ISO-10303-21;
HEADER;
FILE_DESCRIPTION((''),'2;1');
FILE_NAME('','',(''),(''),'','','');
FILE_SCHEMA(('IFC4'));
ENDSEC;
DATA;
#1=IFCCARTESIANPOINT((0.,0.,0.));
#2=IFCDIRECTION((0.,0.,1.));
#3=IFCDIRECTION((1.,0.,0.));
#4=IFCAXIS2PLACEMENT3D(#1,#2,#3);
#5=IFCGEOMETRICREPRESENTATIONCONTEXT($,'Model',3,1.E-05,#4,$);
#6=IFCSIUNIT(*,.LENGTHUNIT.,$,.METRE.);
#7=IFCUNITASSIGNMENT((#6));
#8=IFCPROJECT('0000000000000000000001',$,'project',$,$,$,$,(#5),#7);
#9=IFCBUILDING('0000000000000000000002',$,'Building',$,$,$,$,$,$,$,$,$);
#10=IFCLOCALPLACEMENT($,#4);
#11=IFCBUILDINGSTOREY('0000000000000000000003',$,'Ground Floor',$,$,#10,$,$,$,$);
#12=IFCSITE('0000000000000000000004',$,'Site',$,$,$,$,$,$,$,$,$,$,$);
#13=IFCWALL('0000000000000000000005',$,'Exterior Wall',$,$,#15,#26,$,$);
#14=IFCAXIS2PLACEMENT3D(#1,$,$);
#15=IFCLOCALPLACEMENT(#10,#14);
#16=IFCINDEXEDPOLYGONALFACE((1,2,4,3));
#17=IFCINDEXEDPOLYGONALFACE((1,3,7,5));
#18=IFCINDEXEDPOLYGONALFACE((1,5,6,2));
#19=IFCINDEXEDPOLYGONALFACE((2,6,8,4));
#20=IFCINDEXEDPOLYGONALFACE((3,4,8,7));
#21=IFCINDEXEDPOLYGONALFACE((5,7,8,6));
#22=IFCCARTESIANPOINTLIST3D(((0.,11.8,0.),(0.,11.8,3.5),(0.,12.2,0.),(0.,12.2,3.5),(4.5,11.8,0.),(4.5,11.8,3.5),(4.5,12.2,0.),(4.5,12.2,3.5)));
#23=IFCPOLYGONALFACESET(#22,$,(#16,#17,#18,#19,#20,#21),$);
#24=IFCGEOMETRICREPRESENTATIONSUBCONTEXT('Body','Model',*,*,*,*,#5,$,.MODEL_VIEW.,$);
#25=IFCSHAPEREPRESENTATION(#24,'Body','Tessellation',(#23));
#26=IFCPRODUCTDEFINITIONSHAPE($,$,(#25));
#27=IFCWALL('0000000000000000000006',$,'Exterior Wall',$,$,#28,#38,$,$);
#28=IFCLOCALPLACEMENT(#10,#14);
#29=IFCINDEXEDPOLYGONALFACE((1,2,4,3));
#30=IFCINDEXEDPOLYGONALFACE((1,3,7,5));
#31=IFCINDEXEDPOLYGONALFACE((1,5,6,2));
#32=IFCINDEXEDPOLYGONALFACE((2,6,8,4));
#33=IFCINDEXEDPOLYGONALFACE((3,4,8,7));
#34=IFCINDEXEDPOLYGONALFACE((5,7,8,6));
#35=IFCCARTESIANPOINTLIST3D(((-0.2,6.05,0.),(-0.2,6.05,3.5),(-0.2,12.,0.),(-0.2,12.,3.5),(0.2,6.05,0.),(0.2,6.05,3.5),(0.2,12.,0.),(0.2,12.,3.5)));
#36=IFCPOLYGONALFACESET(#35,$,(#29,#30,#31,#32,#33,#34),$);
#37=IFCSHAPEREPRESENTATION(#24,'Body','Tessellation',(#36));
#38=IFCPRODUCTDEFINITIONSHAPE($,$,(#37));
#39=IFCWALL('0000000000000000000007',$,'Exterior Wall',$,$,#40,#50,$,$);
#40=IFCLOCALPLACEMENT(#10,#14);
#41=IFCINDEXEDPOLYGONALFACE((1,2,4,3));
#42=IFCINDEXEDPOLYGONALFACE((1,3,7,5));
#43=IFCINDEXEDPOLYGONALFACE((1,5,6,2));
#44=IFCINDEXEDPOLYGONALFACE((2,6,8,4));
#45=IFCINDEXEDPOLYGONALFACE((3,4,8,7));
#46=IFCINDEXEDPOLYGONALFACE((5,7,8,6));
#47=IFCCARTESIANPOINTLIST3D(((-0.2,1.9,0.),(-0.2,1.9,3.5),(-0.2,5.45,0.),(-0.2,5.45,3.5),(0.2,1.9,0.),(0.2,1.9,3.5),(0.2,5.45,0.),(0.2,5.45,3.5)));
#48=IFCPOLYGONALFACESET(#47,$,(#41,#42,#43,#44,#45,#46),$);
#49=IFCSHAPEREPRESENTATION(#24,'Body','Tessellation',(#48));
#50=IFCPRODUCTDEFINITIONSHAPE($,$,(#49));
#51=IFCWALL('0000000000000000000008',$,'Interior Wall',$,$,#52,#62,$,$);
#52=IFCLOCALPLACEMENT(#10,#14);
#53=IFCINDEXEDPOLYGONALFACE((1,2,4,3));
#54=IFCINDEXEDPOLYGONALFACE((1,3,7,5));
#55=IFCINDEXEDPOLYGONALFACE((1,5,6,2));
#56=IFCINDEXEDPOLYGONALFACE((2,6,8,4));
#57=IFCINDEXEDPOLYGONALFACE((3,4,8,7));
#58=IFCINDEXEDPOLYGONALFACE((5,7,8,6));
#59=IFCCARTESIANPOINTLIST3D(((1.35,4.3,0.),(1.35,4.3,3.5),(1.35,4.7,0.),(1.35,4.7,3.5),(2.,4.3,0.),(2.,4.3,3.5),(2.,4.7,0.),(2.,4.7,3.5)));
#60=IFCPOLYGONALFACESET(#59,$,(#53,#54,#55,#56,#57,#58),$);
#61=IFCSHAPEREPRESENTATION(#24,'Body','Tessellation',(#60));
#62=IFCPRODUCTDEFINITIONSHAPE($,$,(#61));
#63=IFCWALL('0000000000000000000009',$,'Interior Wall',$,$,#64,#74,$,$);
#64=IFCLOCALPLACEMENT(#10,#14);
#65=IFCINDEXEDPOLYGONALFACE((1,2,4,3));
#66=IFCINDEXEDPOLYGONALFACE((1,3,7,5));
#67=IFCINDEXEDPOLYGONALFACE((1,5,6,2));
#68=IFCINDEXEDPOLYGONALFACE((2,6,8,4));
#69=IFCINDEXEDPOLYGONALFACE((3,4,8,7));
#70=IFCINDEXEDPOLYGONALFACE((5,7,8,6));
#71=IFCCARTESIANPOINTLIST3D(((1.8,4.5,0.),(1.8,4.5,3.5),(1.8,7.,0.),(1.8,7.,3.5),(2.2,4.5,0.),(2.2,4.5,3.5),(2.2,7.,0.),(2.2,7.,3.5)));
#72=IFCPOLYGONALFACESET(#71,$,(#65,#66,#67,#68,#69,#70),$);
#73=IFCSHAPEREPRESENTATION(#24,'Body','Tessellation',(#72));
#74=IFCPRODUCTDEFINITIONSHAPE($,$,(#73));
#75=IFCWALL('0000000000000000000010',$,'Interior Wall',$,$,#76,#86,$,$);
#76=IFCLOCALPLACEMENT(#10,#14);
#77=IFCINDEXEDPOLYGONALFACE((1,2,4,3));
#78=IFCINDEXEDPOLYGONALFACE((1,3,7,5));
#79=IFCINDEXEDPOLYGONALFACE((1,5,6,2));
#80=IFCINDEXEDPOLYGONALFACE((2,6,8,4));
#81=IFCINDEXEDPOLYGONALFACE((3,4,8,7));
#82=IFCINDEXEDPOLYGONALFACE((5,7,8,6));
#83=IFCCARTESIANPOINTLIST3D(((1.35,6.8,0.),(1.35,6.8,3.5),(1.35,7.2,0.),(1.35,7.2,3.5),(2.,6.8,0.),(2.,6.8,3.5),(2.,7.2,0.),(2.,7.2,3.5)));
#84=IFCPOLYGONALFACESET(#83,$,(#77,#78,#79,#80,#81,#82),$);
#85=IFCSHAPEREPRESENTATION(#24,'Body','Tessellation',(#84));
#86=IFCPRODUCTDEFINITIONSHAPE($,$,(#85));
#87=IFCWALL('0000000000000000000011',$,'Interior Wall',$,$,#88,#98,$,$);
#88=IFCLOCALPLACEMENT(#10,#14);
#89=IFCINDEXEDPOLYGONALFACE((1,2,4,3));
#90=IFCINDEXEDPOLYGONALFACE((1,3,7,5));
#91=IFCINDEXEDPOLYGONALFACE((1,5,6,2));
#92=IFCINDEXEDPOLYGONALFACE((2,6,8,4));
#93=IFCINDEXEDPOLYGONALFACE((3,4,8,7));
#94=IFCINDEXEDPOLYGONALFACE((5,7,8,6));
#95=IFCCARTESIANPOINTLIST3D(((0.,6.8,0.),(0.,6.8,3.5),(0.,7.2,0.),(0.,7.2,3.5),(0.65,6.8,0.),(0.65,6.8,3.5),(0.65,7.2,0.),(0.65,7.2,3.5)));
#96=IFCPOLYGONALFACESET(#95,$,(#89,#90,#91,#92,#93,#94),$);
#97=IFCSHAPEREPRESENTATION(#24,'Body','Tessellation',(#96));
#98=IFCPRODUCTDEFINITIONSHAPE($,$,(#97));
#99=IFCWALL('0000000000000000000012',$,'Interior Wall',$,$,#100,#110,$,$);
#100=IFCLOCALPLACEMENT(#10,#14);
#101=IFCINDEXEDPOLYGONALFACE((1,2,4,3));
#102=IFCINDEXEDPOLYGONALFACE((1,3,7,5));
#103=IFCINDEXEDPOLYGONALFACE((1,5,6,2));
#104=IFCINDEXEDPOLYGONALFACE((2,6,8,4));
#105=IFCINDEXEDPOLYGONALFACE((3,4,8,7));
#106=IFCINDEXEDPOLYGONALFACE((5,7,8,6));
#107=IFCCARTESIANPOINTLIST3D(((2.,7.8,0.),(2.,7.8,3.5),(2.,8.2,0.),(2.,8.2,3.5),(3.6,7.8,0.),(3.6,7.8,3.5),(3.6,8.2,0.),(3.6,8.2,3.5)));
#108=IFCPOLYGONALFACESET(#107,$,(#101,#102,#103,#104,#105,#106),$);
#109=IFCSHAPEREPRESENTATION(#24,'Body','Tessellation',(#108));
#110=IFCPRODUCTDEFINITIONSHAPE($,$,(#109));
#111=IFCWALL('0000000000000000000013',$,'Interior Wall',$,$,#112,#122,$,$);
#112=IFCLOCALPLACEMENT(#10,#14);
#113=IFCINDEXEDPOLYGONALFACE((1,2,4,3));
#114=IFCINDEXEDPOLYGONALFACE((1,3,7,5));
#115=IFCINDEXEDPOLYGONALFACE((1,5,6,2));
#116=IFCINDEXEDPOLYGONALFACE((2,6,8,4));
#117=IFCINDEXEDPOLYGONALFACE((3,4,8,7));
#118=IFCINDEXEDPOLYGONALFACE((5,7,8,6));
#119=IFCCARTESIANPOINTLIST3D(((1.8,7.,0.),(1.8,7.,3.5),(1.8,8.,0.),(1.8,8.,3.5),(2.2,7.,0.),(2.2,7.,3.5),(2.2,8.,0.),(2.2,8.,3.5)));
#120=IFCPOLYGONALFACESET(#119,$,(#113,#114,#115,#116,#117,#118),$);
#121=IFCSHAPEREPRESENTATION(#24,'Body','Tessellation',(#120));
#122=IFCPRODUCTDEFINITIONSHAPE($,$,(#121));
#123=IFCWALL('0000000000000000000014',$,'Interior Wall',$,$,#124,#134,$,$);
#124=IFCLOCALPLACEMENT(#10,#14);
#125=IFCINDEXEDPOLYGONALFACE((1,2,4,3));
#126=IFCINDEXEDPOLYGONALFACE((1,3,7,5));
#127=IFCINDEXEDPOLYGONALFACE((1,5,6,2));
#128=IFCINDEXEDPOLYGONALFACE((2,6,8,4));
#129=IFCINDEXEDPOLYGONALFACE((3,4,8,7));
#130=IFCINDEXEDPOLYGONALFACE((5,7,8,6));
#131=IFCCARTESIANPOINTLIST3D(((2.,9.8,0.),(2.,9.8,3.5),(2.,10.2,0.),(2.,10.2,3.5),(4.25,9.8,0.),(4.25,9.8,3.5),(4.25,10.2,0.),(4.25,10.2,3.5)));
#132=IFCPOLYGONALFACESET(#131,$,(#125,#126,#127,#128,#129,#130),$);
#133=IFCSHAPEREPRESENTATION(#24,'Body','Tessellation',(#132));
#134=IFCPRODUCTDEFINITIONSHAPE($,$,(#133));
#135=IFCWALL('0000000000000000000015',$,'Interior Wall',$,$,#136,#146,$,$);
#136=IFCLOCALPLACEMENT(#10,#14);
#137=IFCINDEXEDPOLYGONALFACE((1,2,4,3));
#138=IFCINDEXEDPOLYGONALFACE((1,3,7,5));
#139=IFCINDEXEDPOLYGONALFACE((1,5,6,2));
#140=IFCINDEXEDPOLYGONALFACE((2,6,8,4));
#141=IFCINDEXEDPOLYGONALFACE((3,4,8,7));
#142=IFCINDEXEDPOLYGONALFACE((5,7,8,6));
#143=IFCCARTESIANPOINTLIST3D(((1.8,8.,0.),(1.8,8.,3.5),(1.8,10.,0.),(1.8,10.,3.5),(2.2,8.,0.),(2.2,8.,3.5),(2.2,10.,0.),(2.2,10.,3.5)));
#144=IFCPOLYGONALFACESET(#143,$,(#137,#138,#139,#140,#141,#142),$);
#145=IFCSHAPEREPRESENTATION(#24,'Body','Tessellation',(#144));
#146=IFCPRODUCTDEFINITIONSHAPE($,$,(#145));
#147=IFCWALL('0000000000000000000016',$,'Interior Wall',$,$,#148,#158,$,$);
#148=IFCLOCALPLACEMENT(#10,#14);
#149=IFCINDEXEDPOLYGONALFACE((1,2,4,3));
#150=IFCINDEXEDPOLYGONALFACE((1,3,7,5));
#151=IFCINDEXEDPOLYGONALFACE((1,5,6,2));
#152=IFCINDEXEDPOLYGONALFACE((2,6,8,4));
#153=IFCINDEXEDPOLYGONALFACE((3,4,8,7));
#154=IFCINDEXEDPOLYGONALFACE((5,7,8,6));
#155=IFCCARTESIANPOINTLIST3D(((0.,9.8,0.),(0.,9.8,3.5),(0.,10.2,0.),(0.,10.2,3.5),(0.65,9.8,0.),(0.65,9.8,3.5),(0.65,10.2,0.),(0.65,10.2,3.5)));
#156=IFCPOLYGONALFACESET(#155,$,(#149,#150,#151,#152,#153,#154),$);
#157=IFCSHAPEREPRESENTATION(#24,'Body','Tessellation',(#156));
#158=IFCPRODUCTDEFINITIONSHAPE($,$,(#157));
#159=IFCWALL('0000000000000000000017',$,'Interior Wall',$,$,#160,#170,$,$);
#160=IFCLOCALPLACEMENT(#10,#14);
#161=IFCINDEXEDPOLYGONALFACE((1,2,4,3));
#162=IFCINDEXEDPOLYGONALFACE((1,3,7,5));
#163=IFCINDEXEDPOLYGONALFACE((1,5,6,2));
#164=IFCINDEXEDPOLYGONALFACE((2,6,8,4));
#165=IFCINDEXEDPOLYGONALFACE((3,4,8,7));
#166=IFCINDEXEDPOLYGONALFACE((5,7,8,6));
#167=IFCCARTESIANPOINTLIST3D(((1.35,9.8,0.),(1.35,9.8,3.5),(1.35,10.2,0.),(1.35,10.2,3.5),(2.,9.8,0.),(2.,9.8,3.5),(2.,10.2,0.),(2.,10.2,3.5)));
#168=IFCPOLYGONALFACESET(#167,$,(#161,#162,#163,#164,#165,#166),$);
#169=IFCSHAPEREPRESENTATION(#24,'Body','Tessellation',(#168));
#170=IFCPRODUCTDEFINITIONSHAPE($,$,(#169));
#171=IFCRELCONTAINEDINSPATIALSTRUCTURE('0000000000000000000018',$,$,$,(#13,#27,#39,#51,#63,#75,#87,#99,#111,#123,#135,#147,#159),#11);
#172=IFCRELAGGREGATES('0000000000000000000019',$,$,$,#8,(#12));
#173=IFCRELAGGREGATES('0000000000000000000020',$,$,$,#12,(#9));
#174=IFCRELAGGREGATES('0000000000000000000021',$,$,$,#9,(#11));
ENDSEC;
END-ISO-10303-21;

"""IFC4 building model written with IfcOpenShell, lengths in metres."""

from ifc_helpers import new_model, si_unit, frame, origin_with_axes, place, context, subcontext, project, spatial, indexed_curve, outline, extrude, element, save


model = new_model("IFC4")

# Units and contexts
model_context = context("Model", 3, precision=1e-05, world=origin_with_axes())
body_context = subcontext(model_context, "Body", "Model", "MODEL_VIEW")
ifc_project = project(units=[si_unit("LENGTHUNIT", "METRE")], contexts=[model_context])

# Site, building, storey
site = spatial("IfcSite", under=ifc_project, Name="Site")
building = spatial("IfcBuilding", under=site, Name="Building")
storey_placement = place(None, origin_with_axes())
storey = spatial("IfcBuildingStorey", under=building, at=storey_placement, Name="Ground Floor")

# Walls
wall_1_placement = place(storey_placement, frame((4.5, 12.0, 0.0), z_axis=(0.0, 0.0, 1.0), x_axis=(-1.0, 0.0, 0.0)))
element("IfcWall", 1, at=wall_1_placement, inside=storey, Name="Exterior Wall", context=body_context, shape_type="SweptSolid", body=[
    extrude(outline(indexed_curve([(0.0, 0.0), (0.0, 0.4), (4.5, 0.4), (4.5, 0.0), (0.0, 0.0)], self_intersect=False)), frame((0.0, -0.2, 0.0), z_axis=(0.0, 0.0, 1.0), x_axis=(1.0, 0.0, 0.0)), (0.0, 0.0, 1.0), 3.5),
])
wall_2_placement = place(storey_placement, frame((0.0, 12.0, 0.0), z_axis=(0.0, 0.0, 1.0), x_axis=(0.0, -1.0, 0.0)))
element("IfcWall", 2, at=wall_2_placement, inside=storey, Name="Exterior Wall", context=body_context, shape_type="SweptSolid", body=[
    extrude(outline(indexed_curve([(0.0, 0.0), (0.0, 0.4), (5.95, 0.4), (5.95, 0.0), (0.0, 0.0)], self_intersect=False)), frame((0.0, -0.2, 0.0), z_axis=(0.0, 0.0, 1.0), x_axis=(1.0, 0.0, 0.0)), (0.0, 0.0, 1.0), 3.5),
])
wall_3_placement = place(storey_placement, frame((0.0, 5.45, 0.0), z_axis=(0.0, 0.0, 1.0), x_axis=(0.0, -1.0, 0.0)))
element("IfcWall", 3, at=wall_3_placement, inside=storey, Name="Exterior Wall", context=body_context, shape_type="SweptSolid", body=[
    extrude(outline(indexed_curve([(0.0, 0.0), (0.0, 0.4), (3.55, 0.4), (3.55, 0.0), (0.0, 0.0)], self_intersect=False)), frame((0.0, -0.2, 0.0), z_axis=(0.0, 0.0, 1.0), x_axis=(1.0, 0.0, 0.0)), (0.0, 0.0, 1.0), 3.5),
])
wall_4_placement = place(storey_placement, frame((2.0, 4.5, 0.0), z_axis=(0.0, 0.0, 1.0), x_axis=(-1.0, 0.0, 0.0)))
element("IfcWall", 4, at=wall_4_placement, inside=storey, Name="Interior Wall", context=body_context, shape_type="SweptSolid", body=[
    extrude(outline(indexed_curve([(0.0, 0.0), (0.0, 0.4), (0.65, 0.4), (0.65, 0.0), (0.0, 0.0)], self_intersect=False)), frame((0.0, -0.2, 0.0), z_axis=(0.0, 0.0, 1.0), x_axis=(1.0, 0.0, 0.0)), (0.0, 0.0, 1.0), 3.5),
])
wall_5_placement = place(storey_placement, frame((2.0, 4.5, 0.0), z_axis=(0.0, 0.0, 1.0), x_axis=(0.0, 1.0, 0.0)))
element("IfcWall", 5, at=wall_5_placement, inside=storey, Name="Interior Wall", context=body_context, shape_type="SweptSolid", body=[
    extrude(outline(indexed_curve([(0.0, 0.0), (0.0, 0.4), (2.5, 0.4), (2.5, 0.0), (0.0, 0.0)], self_intersect=False)), frame((0.0, -0.2, 0.0), z_axis=(0.0, 0.0, 1.0), x_axis=(1.0, 0.0, 0.0)), (0.0, 0.0, 1.0), 3.5),
])
for number, where, z_axis, x_axis, name in (
    (6, (2.0, 7.0, 0.0), (0.0, 0.0, 1.0), (-1.0, 0.0, 0.0), "Interior Wall"),
    (7, (0.65, 7.0, 0.0), (0.0, 0.0, 1.0), (-1.0, 0.0, 0.0), "Interior Wall"),
):
    element("IfcWall", number, at=place(storey_placement, frame(where, z_axis=z_axis, x_axis=x_axis)), inside=storey, Name=name, context=body_context, shape_type="SweptSolid", body=[
        extrude(outline(indexed_curve([(0.0, 0.0), (0.0, 0.4), (0.65, 0.4), (0.65, 0.0), (0.0, 0.0)], self_intersect=False)), frame((0.0, -0.2, 0.0), z_axis=(0.0, 0.0, 1.0), x_axis=(1.0, 0.0, 0.0)), (0.0, 0.0, 1.0), 3.5),
    ])
wall_6_placement = place(storey_placement, frame((3.6, 8.0, 0.0), z_axis=(0.0, 0.0, 1.0), x_axis=(-1.0, 0.0, 0.0)))
element("IfcWall", 8, at=wall_6_placement, inside=storey, Name="Interior Wall", context=body_context, shape_type="SweptSolid", body=[
    extrude(outline(indexed_curve([(0.0, 0.0), (0.0, 0.4), (1.6, 0.4), (1.6, 0.0), (0.0, 0.0)], self_intersect=False)), frame((0.0, -0.2, 0.0), z_axis=(0.0, 0.0, 1.0), x_axis=(1.0, 0.0, 0.0)), (0.0, 0.0, 1.0), 3.5),
])
wall_7_placement = place(storey_placement, frame((2.0, 8.0, 0.0), z_axis=(0.0, 0.0, 1.0), x_axis=(0.0, -1.0, 0.0)))
element("IfcWall", 9, at=wall_7_placement, inside=storey, Name="Interior Wall", context=body_context, shape_type="SweptSolid", body=[
    extrude(outline(indexed_curve([(0.0, 0.0), (0.0, 0.4), (1.0, 0.4), (1.0, 0.0), (0.0, 0.0)], self_intersect=False)), frame((0.0, -0.2, 0.0), z_axis=(0.0, 0.0, 1.0), x_axis=(1.0, 0.0, 0.0)), (0.0, 0.0, 1.0), 3.5),
])
wall_8_placement = place(storey_placement, frame((4.25, 10.0, 0.0), z_axis=(0.0, 0.0, 1.0), x_axis=(-1.0, 0.0, 0.0)))
element("IfcWall", 10, at=wall_8_placement, inside=storey, Name="Interior Wall", context=body_context, shape_type="SweptSolid", body=[
    extrude(outline(indexed_curve([(0.0, 0.0), (0.0, 0.4), (2.25, 0.4), (2.25, 0.0), (0.0, 0.0)], self_intersect=False)), frame((0.0, -0.2, 0.0), z_axis=(0.0, 0.0, 1.0), x_axis=(1.0, 0.0, 0.0)), (0.0, 0.0, 1.0), 3.5),
])
wall_9_placement = place(storey_placement, frame((2.0, 10.0, 0.0), z_axis=(0.0, 0.0, 1.0), x_axis=(0.0, -1.0, 0.0)))
element("IfcWall", 11, at=wall_9_placement, inside=storey, Name="Interior Wall", context=body_context, shape_type="SweptSolid", body=[
    extrude(outline(indexed_curve([(0.0, 0.0), (0.0, 0.4), (2.0, 0.4), (2.0, 0.0), (0.0, 0.0)], self_intersect=False)), frame((0.0, -0.2, 0.0), z_axis=(0.0, 0.0, 1.0), x_axis=(1.0, 0.0, 0.0)), (0.0, 0.0, 1.0), 3.5),
])
wall_10_placement = place(storey_placement, frame((0.0, 10.0, 0.0), z_axis=(0.0, 0.0, 1.0), x_axis=(1.0, 0.0, 0.0)))
element("IfcWall", 12, at=wall_10_placement, inside=storey, Name="Interior Wall", context=body_context, shape_type="SweptSolid", body=[
    extrude(outline(indexed_curve([(0.0, 0.0), (0.0, 0.4), (0.65, 0.4), (0.65, 0.0), (0.0, 0.0)], self_intersect=False)), frame((0.0, -0.2, 0.0), z_axis=(0.0, 0.0, 1.0), x_axis=(1.0, 0.0, 0.0)), (0.0, 0.0, 1.0), 3.5),
])
wall_11_placement = place(storey_placement, frame((1.35, 10.0, 0.0), z_axis=(0.0, 0.0, 1.0), x_axis=(1.0, 0.0, 0.0)))
element("IfcWall", 13, at=wall_11_placement, inside=storey, Name="Interior Wall", context=body_context, shape_type="SweptSolid", body=[
    extrude(outline(indexed_curve([(0.0, 0.0), (0.0, 0.4), (0.65, 0.4), (0.65, 0.0), (0.0, 0.0)], self_intersect=False)), frame((0.0, -0.2, 0.0), z_axis=(0.0, 0.0, 1.0), x_axis=(1.0, 0.0, 0.0)), (0.0, 0.0, 1.0), 3.5),
])

save(model, "model.ifc")
